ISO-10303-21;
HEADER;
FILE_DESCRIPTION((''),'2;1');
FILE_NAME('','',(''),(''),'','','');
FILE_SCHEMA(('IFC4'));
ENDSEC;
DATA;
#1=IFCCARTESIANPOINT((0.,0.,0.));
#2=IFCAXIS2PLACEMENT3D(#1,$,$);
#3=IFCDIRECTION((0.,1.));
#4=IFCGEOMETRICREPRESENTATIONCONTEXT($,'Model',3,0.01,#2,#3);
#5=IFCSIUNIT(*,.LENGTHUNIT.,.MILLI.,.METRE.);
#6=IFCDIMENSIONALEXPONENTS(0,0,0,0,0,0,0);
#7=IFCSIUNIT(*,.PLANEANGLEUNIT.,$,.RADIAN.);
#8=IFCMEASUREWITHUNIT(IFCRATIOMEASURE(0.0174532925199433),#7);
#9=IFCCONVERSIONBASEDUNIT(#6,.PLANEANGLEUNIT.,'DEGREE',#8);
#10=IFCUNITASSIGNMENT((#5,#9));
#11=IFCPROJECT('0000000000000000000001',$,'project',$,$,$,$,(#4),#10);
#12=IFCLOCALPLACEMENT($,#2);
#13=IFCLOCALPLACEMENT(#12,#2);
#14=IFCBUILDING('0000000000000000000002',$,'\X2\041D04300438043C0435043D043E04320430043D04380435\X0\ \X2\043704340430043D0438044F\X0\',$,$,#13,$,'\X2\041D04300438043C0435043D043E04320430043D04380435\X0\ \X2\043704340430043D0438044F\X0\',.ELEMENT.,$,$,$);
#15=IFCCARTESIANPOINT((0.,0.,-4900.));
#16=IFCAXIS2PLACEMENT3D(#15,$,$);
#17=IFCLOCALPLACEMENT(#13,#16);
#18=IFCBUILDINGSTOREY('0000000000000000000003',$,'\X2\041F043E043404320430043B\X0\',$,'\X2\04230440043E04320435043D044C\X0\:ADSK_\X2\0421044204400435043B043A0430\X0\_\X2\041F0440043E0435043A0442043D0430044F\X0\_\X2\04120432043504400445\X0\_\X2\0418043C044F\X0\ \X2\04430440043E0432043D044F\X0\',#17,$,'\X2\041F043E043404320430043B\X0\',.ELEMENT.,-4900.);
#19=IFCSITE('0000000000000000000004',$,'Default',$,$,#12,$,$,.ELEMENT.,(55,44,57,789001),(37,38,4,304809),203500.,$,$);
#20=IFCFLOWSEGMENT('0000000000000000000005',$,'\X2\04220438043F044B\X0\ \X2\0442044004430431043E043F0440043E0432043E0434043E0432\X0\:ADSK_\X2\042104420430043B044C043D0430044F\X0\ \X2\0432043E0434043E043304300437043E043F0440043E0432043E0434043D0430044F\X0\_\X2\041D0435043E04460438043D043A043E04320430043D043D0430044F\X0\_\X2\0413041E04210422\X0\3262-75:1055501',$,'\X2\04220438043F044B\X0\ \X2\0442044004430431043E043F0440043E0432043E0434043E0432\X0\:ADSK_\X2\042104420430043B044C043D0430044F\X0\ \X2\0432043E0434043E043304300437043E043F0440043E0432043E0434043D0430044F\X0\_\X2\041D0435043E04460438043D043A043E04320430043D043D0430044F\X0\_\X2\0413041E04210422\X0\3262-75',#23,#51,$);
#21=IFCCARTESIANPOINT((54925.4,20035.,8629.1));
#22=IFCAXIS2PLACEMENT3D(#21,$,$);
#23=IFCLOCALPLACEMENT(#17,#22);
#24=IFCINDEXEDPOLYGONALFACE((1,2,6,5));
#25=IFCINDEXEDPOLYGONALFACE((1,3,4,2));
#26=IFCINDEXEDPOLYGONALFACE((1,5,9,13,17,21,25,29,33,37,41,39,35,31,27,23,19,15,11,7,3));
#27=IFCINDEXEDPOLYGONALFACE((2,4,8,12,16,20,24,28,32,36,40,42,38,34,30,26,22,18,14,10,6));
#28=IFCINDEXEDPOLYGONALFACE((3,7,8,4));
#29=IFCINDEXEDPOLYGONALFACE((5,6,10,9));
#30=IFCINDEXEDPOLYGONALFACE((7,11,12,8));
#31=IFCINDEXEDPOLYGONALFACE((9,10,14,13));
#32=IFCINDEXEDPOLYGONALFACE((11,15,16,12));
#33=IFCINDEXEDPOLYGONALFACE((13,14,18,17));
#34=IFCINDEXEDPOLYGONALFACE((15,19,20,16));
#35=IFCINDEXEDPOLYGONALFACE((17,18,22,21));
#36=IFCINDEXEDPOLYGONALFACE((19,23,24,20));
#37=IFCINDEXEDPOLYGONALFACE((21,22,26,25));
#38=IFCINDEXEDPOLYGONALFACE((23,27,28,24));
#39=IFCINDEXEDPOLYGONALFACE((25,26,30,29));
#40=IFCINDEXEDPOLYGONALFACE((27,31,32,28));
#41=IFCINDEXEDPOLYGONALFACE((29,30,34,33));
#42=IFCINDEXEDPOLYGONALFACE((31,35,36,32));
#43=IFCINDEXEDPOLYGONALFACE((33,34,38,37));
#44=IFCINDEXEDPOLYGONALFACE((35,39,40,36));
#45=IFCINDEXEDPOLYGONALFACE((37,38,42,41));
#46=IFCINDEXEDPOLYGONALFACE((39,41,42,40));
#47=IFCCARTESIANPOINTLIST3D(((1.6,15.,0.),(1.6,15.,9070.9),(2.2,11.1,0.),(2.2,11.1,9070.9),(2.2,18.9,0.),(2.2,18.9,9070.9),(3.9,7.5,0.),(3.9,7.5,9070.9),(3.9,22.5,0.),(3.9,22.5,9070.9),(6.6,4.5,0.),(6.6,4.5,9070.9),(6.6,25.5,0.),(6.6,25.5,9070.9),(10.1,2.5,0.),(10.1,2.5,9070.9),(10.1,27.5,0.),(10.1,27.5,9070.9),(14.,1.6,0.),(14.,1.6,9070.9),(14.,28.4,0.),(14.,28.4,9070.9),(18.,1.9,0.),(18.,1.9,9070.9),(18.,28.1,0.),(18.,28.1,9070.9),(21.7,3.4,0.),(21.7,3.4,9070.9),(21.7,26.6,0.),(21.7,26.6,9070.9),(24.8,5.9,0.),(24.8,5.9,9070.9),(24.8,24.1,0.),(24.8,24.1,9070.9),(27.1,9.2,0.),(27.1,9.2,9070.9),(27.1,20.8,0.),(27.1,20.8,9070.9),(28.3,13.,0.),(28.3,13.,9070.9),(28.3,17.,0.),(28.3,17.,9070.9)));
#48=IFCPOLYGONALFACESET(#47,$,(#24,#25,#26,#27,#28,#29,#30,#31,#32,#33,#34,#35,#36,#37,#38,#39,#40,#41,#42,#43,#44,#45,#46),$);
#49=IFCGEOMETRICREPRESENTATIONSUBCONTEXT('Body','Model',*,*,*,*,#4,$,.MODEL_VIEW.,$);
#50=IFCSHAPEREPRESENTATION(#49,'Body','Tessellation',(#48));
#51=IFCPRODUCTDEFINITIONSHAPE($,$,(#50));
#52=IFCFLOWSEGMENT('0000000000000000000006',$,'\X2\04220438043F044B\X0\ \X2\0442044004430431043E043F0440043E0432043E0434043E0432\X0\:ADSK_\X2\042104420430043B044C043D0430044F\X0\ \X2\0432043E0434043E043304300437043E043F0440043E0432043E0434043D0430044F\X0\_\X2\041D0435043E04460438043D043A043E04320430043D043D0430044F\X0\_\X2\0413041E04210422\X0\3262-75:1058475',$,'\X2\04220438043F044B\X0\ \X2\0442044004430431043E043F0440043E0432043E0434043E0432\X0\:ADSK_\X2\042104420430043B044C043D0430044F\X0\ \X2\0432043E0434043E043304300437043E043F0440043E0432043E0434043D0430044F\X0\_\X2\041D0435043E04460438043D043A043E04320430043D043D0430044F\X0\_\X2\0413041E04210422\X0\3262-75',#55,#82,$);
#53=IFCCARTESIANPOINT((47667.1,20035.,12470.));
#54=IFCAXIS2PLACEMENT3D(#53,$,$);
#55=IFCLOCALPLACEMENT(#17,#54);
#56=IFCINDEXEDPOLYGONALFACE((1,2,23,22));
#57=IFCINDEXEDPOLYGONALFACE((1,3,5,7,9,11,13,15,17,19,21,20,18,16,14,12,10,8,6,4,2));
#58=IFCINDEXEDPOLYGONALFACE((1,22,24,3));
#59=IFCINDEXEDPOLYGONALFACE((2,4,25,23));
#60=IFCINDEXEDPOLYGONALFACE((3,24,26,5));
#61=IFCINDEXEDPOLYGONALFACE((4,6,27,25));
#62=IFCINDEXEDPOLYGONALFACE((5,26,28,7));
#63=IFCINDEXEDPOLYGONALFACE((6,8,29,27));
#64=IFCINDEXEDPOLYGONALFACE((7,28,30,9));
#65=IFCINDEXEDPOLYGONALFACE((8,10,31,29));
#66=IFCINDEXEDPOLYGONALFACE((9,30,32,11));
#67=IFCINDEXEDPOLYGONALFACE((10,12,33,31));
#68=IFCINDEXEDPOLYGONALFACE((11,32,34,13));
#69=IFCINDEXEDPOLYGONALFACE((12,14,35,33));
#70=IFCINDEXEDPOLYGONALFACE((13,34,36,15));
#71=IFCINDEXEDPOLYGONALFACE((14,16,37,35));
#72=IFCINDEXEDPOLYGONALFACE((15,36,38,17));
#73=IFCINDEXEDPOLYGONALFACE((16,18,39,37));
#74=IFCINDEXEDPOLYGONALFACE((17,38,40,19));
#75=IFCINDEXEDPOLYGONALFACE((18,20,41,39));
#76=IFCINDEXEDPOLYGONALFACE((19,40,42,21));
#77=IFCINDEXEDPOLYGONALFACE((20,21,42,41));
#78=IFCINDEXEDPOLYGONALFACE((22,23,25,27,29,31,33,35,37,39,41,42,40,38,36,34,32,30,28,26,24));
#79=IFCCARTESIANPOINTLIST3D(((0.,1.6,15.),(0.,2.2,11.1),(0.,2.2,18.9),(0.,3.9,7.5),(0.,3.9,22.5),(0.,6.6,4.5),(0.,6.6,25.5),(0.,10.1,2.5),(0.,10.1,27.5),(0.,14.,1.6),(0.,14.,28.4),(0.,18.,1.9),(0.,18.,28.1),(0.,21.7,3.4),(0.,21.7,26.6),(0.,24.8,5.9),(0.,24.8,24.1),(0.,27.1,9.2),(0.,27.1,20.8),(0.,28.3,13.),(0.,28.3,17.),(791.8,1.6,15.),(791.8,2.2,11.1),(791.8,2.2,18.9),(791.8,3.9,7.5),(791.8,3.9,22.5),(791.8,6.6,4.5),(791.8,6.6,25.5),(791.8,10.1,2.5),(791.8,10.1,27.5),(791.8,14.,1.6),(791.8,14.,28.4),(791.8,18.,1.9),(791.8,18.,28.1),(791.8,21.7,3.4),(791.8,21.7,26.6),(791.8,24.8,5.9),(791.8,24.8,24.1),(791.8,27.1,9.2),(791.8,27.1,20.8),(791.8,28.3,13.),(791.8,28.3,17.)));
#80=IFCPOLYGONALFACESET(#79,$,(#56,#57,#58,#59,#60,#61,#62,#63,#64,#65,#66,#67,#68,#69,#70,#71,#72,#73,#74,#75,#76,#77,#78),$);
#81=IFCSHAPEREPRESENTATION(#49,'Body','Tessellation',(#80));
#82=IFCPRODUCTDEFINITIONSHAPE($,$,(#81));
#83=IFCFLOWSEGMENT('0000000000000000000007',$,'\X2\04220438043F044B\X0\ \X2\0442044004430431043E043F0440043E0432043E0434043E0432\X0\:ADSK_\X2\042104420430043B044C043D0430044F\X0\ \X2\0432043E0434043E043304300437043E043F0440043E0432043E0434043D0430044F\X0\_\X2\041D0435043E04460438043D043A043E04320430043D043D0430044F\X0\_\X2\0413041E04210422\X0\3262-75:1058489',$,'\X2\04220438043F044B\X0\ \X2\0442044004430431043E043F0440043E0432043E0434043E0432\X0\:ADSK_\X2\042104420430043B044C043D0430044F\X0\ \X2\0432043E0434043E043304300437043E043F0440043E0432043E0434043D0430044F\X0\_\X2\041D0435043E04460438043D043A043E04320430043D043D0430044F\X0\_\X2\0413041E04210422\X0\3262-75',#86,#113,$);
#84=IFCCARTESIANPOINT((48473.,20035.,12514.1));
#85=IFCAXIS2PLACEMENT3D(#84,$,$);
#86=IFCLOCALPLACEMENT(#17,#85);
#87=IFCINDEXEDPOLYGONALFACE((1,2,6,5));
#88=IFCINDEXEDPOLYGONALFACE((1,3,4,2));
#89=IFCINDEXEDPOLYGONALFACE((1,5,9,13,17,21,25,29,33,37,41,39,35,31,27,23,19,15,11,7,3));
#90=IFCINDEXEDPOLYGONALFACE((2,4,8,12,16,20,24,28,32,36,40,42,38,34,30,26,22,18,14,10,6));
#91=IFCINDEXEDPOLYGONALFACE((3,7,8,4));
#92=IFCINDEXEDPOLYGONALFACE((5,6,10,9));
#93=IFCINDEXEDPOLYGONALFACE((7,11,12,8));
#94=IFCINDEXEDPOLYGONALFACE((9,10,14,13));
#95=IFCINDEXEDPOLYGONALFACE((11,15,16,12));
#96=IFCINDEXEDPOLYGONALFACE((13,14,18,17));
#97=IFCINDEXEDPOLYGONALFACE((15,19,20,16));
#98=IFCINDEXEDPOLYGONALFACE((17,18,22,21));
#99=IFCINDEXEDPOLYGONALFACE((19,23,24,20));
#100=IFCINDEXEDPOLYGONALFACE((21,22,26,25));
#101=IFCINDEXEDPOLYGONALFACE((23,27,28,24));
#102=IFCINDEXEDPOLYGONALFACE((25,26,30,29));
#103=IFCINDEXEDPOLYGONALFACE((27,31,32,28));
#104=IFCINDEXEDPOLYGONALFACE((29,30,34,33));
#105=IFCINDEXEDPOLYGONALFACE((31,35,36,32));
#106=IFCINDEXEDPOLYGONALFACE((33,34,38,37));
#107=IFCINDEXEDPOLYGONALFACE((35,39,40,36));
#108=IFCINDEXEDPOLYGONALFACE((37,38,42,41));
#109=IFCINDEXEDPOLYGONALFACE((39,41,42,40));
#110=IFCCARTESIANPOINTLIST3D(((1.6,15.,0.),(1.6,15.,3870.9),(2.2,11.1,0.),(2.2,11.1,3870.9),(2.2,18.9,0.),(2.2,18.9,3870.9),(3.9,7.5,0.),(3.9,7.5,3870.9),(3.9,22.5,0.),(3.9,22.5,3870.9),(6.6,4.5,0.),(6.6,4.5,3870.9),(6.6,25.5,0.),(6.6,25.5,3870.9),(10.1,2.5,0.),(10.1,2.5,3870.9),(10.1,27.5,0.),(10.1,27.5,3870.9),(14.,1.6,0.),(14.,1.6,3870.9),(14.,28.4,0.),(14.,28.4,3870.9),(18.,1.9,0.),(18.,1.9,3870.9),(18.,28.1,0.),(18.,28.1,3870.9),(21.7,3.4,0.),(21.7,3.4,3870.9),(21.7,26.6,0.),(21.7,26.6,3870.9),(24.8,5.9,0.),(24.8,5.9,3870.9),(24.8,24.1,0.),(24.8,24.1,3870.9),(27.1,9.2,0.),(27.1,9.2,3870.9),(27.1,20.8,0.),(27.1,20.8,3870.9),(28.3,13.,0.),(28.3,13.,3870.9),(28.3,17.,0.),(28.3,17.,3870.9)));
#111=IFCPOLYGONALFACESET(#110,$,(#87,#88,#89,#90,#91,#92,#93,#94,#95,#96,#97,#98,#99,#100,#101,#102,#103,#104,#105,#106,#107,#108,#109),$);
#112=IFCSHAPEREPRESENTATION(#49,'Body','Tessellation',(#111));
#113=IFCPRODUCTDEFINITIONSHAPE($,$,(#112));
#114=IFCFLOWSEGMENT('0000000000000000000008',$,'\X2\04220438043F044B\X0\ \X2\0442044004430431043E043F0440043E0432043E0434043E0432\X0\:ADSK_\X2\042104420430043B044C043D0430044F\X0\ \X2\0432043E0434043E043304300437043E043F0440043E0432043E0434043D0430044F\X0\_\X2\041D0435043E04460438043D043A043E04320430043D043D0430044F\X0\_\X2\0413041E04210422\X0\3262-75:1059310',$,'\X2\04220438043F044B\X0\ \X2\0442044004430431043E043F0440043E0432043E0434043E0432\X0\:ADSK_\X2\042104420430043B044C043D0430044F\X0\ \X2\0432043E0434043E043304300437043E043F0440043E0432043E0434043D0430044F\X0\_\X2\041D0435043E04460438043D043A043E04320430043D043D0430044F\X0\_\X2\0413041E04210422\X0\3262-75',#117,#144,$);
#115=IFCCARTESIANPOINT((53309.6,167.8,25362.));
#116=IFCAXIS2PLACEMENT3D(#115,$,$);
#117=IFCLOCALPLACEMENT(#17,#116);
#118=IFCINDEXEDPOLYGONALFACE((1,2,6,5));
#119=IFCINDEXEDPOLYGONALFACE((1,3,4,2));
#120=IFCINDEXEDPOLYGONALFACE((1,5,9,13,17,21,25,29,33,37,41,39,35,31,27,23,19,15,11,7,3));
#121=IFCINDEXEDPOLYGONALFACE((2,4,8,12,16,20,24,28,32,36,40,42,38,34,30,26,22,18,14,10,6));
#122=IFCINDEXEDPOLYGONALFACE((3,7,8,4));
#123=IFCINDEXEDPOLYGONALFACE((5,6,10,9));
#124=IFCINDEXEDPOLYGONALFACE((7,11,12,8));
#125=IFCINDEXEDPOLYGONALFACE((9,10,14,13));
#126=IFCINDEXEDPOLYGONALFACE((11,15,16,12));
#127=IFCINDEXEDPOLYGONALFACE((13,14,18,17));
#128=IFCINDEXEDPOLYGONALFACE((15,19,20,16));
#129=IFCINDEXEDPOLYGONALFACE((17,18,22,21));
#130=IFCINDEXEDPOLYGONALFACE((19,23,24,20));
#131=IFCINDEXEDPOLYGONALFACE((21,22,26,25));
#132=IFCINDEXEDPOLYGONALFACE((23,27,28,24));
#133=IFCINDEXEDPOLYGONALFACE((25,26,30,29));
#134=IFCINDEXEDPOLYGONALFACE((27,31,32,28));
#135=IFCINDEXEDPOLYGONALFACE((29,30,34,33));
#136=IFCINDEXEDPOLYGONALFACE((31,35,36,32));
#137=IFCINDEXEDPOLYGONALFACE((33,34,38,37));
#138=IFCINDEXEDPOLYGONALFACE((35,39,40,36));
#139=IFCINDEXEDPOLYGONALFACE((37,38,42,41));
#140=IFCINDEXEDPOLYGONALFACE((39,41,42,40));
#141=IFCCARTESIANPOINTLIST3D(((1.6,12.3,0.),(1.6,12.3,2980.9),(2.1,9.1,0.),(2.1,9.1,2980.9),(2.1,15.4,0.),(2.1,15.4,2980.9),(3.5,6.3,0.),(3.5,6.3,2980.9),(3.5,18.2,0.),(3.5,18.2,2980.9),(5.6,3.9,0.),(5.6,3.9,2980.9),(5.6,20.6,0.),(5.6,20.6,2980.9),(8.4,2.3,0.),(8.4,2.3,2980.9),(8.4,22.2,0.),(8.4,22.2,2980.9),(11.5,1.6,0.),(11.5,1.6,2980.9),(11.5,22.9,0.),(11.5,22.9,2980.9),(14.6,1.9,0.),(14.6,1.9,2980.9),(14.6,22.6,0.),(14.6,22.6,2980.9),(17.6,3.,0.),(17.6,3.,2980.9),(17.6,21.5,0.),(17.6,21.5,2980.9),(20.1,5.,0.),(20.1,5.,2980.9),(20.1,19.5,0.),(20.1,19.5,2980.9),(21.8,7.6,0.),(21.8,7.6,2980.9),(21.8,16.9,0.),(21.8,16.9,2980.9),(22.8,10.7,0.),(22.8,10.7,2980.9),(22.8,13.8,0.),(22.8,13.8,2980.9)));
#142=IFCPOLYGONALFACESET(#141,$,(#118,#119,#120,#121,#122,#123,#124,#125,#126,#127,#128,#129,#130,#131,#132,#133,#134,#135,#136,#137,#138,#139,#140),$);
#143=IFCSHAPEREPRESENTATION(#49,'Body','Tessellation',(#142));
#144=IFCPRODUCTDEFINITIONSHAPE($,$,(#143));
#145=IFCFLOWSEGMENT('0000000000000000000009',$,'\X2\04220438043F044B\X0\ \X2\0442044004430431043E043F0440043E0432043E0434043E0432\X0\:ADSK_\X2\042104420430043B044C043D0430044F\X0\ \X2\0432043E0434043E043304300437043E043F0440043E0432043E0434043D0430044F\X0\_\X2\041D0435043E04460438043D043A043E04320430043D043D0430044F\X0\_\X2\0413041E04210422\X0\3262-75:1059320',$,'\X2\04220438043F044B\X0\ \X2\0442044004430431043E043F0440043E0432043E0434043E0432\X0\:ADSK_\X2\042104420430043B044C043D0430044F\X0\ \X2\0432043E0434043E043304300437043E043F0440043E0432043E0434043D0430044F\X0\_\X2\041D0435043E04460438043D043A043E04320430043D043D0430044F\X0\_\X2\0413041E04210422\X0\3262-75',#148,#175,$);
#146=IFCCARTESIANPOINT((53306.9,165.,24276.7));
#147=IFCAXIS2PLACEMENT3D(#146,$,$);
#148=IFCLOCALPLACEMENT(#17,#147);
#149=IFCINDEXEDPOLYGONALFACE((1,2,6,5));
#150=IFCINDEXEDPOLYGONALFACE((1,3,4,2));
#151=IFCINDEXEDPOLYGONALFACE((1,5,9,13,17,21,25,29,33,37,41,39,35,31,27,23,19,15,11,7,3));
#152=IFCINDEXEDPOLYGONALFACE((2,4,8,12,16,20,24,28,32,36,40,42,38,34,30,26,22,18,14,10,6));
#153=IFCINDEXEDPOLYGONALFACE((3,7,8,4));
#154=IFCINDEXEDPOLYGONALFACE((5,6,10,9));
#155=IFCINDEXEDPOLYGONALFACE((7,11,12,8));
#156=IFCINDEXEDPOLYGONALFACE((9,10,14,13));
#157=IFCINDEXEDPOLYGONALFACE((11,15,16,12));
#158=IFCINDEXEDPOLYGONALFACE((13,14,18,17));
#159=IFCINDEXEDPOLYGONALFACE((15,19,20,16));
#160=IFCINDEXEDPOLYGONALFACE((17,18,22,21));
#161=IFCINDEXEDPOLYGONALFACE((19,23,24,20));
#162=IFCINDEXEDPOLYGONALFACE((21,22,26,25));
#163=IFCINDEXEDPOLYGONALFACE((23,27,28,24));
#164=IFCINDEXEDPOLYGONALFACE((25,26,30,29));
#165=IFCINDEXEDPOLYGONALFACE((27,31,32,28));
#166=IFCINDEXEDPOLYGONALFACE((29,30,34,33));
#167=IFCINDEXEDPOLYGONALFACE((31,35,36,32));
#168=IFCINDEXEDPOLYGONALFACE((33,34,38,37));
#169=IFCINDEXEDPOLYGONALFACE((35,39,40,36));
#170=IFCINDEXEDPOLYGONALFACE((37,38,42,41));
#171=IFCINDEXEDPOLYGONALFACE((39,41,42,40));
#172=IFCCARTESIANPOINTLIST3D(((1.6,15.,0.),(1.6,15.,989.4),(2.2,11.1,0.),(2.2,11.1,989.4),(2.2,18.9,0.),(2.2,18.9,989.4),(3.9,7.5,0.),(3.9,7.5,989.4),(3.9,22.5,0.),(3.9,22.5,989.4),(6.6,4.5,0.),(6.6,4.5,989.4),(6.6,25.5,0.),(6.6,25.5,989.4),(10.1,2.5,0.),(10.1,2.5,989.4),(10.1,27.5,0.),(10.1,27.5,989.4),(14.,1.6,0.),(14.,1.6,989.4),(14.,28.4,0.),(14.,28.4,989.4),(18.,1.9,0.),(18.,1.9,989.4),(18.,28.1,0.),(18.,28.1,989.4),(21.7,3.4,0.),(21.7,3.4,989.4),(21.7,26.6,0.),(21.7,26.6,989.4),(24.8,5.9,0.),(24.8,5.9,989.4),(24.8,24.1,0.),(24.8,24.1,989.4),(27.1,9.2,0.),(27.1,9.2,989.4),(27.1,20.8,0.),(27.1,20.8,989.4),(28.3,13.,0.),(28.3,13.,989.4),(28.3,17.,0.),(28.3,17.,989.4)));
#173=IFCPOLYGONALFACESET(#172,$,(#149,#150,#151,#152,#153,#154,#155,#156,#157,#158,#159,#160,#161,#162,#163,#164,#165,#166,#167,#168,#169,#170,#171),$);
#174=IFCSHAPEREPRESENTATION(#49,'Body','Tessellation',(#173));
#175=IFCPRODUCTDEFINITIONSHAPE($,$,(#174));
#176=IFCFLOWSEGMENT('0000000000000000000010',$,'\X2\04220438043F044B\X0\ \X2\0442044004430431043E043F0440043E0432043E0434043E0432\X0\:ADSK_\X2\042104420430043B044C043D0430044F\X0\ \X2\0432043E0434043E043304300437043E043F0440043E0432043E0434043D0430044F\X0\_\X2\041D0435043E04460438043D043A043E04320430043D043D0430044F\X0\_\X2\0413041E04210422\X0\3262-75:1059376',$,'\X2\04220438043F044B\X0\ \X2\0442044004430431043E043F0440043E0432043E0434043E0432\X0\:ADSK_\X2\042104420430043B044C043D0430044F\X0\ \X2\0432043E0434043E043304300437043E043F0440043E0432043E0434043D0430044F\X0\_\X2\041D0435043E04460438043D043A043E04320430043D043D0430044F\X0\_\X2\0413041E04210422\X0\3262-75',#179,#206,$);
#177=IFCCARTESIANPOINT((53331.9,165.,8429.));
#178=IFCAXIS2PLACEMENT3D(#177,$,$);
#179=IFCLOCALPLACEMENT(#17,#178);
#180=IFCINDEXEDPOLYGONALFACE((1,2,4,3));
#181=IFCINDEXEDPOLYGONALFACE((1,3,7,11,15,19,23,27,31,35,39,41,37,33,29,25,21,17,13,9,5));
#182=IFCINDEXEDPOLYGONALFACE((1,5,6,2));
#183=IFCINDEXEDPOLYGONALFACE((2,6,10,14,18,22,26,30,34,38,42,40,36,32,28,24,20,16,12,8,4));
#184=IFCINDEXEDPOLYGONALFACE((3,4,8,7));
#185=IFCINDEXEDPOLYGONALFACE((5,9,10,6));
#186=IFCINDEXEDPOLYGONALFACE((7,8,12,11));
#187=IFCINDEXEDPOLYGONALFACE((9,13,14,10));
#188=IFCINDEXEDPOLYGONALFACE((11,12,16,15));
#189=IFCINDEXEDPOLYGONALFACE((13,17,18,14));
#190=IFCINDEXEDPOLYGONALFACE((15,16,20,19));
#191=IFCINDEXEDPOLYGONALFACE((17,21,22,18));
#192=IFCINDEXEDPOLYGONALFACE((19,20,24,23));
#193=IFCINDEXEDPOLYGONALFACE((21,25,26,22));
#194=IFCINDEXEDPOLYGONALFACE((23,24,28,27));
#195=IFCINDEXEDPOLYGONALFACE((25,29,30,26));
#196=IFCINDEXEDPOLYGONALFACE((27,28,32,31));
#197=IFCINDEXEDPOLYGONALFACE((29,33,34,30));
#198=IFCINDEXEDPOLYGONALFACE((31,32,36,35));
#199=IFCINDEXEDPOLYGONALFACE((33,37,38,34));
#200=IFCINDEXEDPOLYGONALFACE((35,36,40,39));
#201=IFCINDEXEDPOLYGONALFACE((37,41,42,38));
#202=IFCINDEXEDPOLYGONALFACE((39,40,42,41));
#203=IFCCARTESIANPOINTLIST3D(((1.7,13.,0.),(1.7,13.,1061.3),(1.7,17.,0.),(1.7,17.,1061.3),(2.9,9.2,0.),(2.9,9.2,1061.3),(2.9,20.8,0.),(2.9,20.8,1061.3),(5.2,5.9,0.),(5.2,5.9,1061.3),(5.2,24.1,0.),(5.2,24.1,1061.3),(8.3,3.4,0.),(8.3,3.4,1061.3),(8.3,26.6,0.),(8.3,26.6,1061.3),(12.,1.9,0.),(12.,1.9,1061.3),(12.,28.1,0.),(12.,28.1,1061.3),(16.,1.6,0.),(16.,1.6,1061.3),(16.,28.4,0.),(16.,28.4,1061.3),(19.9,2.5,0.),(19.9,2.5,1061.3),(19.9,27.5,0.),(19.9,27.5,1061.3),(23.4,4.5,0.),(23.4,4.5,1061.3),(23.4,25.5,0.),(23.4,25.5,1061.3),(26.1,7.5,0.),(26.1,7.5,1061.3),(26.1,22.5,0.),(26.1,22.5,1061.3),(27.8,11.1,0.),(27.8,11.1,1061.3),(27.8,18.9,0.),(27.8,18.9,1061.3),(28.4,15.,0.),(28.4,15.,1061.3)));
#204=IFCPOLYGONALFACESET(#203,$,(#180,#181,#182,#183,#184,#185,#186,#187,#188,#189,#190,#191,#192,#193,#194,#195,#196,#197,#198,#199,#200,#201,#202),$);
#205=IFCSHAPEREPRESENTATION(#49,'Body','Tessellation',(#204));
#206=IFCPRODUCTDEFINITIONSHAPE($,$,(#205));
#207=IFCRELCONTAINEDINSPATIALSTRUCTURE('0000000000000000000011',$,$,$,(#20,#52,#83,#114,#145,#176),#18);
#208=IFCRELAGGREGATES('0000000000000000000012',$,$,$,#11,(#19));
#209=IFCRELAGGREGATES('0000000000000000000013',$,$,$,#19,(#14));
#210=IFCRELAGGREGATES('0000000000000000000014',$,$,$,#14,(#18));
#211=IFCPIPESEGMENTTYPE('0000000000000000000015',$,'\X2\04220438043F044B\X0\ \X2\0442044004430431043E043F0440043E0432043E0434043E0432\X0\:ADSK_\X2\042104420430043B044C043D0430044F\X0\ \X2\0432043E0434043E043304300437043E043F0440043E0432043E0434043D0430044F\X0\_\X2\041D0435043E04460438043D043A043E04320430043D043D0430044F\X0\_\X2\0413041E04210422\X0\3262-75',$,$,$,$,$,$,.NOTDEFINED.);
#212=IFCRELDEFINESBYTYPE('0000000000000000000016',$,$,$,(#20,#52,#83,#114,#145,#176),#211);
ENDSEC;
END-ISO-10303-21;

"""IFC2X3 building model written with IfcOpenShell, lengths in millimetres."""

from ifc_helpers import new_model, entity, si_unit, converted_unit, direction, frame, origin, origin_2d_with_axis, place, context, subcontext, project, spatial, circle, extrude, type_object, element, save


model = new_model("IFC2X3")

# Units and contexts
model_context = context("Model", 3, precision=0.01, world=origin(), true_north=direction((0.0, 1.0)))
body_context = subcontext(model_context, "Body", "Model", "MODEL_VIEW")
ifc_project = project(units=[si_unit("LENGTHUNIT", "METRE", prefix="MILLI"), converted_unit("PLANEANGLEUNIT", "DEGREE", entity("IfcRatioMeasure", 0.0174532925199433), si_unit("PLANEANGLEUNIT", "RADIAN"), dimensions=[0, 0, 0, 0, 0, 0, 0])], contexts=[model_context])

# Site, building, storey
site_placement = place(None, origin())
site = spatial("IfcSite", under=ifc_project, at=site_placement, Name="Default", CompositionType="ELEMENT", RefLatitude=(55, 44, 57, 789001), RefLongitude=(37, 38, 4, 304809), RefElevation=203500.0)
building_placement = place(site_placement, origin())
building = spatial("IfcBuilding", under=site, at=building_placement, Name="Наименование здания", LongName="Наименование здания", CompositionType="ELEMENT")
storey_placement = place(building_placement, frame((0.0, 0.0, -4900.0)))
storey = spatial("IfcBuildingStorey", under=building, at=storey_placement, Name="Подвал", ObjectType="Уровень:ADSK_Стрелка_Проектная_Вверх_Имя уровня", LongName="Подвал", CompositionType="ELEMENT", Elevation=-4900.0)

# Flow segments
pipe_segment_type = type_object("IfcPipeSegmentType", Name="Типы трубопроводов:ADSK_Стальная водогазопроводная_Неоцинкованная_ГОСТ3262-75", PredefinedType="NOTDEFINED")
flow_segment_1_placement = place(storey_placement, frame((54925.4, 20035.0, 8629.1)))
element("IfcFlowSegment", 1, at=flow_segment_1_placement, inside=storey, type_object=pipe_segment_type, Name="Типы трубопроводов:ADSK_Стальная водогазопроводная_Неоцинкованная_ГОСТ3262-75:1055501", ObjectType="Типы трубопроводов:ADSK_Стальная водогазопроводная_Неоцинкованная_ГОСТ3262-75", context=body_context, shape_type="SweptSolid", body=[
    extrude(circle(Radius=13.4, at=origin_2d_with_axis()), frame((15.0, 15.0, 0.0), z_axis=(0.0, 0.0, 1.0), x_axis=(-1.0, 0.0, 0.0)), (0.0, 0.0, 1.0), 9070.9),
])
flow_segment_2_placement = place(storey_placement, frame((47667.1, 20035.0, 12470.0)))
element("IfcFlowSegment", 2, at=flow_segment_2_placement, inside=storey, type_object=pipe_segment_type, Name="Типы трубопроводов:ADSK_Стальная водогазопроводная_Неоцинкованная_ГОСТ3262-75:1058475", ObjectType="Типы трубопроводов:ADSK_Стальная водогазопроводная_Неоцинкованная_ГОСТ3262-75", context=body_context, shape_type="SweptSolid", body=[
    extrude(circle(Radius=13.4, at=origin_2d_with_axis()), frame((0.0, 15.0, 15.0), z_axis=(1.0, 0.0, 0.0), x_axis=(0.0, -1.0, 0.0)), (0.0, 0.0, 1.0), 791.8),
])
flow_segment_3_placement = place(storey_placement, frame((48473.0, 20035.0, 12514.1)))
element("IfcFlowSegment", 3, at=flow_segment_3_placement, inside=storey, type_object=pipe_segment_type, Name="Типы трубопроводов:ADSK_Стальная водогазопроводная_Неоцинкованная_ГОСТ3262-75:1058489", ObjectType="Типы трубопроводов:ADSK_Стальная водогазопроводная_Неоцинкованная_ГОСТ3262-75", context=body_context, shape_type="SweptSolid", body=[
    extrude(circle(Radius=13.4, at=origin_2d_with_axis()), frame((15.0, 15.0, 0.0), z_axis=(0.0, 0.0, 1.0), x_axis=(-1.0, 0.0, 0.0)), (0.0, 0.0, 1.0), 3870.9),
])
flow_segment_4_placement = place(storey_placement, frame((53309.6, 167.8, 25362.0)))
element("IfcFlowSegment", 4, at=flow_segment_4_placement, inside=storey, type_object=pipe_segment_type, Name="Типы трубопроводов:ADSK_Стальная водогазопроводная_Неоцинкованная_ГОСТ3262-75:1059310", ObjectType="Типы трубопроводов:ADSK_Стальная водогазопроводная_Неоцинкованная_ГОСТ3262-75", context=body_context, shape_type="SweptSolid", body=[
    extrude(circle(Radius=10.7, at=origin_2d_with_axis()), frame((12.2, 12.2, 0.0), z_axis=(0.0, 0.0, 1.0), x_axis=(-1.0, 0.0, 0.0)), (0.0, 0.0, 1.0), 2980.9),
])
flow_segment_5_placement = place(storey_placement, frame((53306.9, 165.0, 24276.7)))
element("IfcFlowSegment", 5, at=flow_segment_5_placement, inside=storey, type_object=pipe_segment_type, Name="Типы трубопроводов:ADSK_Стальная водогазопроводная_Неоцинкованная_ГОСТ3262-75:1059320", ObjectType="Типы трубопроводов:ADSK_Стальная водогазопроводная_Неоцинкованная_ГОСТ3262-75", context=body_context, shape_type="SweptSolid", body=[
    extrude(circle(Radius=13.4, at=origin_2d_with_axis()), frame((15.0, 15.0, 0.0), z_axis=(0.0, 0.0, 1.0), x_axis=(-1.0, 0.0, 0.0)), (0.0, 0.0, 1.0), 989.4),
])
flow_segment_6_placement = place(storey_placement, frame((53331.9, 165.0, 8429.0)))
element("IfcFlowSegment", 6, at=flow_segment_6_placement, inside=storey, type_object=pipe_segment_type, Name="Типы трубопроводов:ADSK_Стальная водогазопроводная_Неоцинкованная_ГОСТ3262-75:1059376", ObjectType="Типы трубопроводов:ADSK_Стальная водогазопроводная_Неоцинкованная_ГОСТ3262-75", context=body_context, shape_type="SweptSolid", body=[
    extrude(circle(Radius=13.4, at=origin_2d_with_axis()), frame((15.0, 15.0, 0.0)), (0.0, 0.0, 1.0), 1061.3),
])

save(model, "model.ifc")
